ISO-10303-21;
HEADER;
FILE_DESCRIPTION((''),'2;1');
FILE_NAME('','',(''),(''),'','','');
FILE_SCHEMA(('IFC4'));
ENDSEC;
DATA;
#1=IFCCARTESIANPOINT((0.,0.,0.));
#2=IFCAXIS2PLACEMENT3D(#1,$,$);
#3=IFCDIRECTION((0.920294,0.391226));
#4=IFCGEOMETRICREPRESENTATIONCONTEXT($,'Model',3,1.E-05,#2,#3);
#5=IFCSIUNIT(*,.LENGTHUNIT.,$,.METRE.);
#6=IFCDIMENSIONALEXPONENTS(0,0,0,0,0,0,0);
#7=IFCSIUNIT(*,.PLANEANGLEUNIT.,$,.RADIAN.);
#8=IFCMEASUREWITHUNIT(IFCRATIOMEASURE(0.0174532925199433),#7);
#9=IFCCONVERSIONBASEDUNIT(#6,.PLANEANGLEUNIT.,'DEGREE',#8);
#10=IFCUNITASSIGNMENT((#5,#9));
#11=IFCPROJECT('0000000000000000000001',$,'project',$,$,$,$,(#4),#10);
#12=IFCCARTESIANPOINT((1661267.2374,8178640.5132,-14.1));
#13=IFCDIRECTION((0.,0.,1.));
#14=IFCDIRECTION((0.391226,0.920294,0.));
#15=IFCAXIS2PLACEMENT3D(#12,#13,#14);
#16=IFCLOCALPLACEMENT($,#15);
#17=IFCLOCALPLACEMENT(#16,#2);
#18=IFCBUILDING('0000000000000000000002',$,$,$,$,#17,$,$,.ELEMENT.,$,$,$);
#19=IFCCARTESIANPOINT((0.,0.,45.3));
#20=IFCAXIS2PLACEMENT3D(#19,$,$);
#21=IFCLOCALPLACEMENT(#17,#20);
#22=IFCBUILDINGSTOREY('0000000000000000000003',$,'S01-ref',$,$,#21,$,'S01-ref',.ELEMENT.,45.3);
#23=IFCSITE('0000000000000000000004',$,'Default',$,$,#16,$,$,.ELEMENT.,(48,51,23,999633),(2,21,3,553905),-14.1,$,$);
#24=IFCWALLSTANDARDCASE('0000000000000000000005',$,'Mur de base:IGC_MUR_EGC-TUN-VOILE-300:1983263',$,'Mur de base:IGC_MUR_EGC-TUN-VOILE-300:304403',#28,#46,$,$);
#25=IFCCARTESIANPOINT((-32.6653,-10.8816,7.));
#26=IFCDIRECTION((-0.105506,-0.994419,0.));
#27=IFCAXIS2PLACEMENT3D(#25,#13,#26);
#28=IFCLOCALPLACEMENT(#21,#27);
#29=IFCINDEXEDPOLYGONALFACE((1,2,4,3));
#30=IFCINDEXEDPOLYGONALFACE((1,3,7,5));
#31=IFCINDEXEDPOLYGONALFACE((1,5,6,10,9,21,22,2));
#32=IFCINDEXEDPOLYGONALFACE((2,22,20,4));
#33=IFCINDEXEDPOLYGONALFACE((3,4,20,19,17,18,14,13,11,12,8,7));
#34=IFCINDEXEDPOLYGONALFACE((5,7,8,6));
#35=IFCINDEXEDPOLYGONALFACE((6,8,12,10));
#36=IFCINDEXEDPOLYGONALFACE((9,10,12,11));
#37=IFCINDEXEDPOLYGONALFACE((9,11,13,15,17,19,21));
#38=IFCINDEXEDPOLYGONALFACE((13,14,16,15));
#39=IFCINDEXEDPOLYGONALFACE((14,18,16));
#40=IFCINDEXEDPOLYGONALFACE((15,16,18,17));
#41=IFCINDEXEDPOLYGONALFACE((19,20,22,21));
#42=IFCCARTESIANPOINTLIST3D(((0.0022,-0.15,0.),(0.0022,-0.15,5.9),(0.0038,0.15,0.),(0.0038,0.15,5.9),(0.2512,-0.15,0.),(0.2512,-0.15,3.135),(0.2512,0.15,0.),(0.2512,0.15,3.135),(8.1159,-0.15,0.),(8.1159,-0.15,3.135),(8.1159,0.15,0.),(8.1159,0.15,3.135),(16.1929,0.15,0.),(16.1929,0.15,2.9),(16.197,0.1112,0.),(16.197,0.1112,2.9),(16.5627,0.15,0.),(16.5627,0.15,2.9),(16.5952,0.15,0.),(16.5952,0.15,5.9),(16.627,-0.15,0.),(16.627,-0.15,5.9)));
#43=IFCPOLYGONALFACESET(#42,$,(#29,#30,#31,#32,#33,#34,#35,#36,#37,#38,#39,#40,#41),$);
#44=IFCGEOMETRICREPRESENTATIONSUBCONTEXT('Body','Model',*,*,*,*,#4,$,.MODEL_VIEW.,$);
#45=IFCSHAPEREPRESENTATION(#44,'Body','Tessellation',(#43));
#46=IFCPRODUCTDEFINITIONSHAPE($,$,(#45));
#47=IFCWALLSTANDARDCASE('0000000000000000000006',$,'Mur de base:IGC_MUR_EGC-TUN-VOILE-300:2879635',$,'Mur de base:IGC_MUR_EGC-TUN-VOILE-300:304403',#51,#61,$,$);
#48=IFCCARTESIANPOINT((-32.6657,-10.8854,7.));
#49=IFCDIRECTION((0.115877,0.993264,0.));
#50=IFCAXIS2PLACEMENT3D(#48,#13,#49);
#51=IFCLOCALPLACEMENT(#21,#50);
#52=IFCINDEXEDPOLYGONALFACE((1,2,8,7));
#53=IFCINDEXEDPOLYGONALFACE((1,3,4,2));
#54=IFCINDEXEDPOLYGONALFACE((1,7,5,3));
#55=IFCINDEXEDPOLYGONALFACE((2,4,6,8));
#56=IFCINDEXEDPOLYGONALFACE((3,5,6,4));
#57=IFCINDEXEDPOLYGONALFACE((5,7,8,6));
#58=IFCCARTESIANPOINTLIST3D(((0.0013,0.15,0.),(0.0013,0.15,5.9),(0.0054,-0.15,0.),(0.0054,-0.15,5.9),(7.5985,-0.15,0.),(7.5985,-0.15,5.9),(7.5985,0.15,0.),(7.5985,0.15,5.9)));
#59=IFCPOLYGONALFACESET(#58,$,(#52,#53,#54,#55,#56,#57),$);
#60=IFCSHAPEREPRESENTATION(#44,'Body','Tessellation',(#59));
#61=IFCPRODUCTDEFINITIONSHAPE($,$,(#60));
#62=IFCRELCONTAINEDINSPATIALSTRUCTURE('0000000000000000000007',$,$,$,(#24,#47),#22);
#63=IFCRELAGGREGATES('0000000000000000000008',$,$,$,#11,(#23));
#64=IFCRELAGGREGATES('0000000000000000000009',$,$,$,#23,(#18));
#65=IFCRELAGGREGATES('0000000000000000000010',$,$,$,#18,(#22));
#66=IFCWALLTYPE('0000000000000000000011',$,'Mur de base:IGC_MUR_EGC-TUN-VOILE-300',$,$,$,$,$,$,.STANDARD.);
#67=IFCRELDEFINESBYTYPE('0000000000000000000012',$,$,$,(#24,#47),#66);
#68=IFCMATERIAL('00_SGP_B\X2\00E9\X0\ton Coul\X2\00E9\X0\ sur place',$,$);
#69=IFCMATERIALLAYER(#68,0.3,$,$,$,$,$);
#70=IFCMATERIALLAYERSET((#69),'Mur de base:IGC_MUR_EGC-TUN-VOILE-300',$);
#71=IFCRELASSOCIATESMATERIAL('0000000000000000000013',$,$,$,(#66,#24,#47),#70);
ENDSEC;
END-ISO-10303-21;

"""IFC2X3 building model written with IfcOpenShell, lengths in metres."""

from ifc_helpers import new_model, entity, si_unit, converted_unit, direction, frame, frame_2d, origin, origin_2d_with_axis, place, context, subcontext, project, spatial, polyline, rectangle, outline, extrude, material, layer, layer_set, layer_usage, type_object, element, save


model = new_model("IFC2X3")

# Units and contexts
model_context = context("Model", 3, precision=1e-05, world=origin(), true_north=direction((0.920294, 0.391226)))
body_context = subcontext(model_context, "Body", "Model", "MODEL_VIEW")
ifc_project = project(units=[si_unit("LENGTHUNIT", "METRE"), converted_unit("PLANEANGLEUNIT", "DEGREE", entity("IfcRatioMeasure", 0.0174532925199433), si_unit("PLANEANGLEUNIT", "RADIAN"), dimensions=[0, 0, 0, 0, 0, 0, 0])], contexts=[model_context])

# Site, building, storey
site_placement = place(None, frame((1661267.2374, 8178640.5132, -14.1), z_axis=(0.0, 0.0, 1.0), x_axis=(0.391226, 0.920294, 0.0)))
site = spatial("IfcSite", under=ifc_project, at=site_placement, Name="Default", CompositionType="ELEMENT", RefLatitude=(48, 51, 23, 999633), RefLongitude=(2, 21, 3, 553905), RefElevation=-14.1)
building_placement = place(site_placement, origin())
building = spatial("IfcBuilding", under=site, at=building_placement, CompositionType="ELEMENT")
storey_placement = place(building_placement, frame((0.0, 0.0, 45.3)))
storey = spatial("IfcBuildingStorey", under=building, at=storey_placement, Name="S01-ref", LongName="S01-ref", CompositionType="ELEMENT", Elevation=45.3)

# Shared definitions
ifc_material_1 = material(Name="00_SGP_Béton Coulé sur place")

# Wall, openings
ifc_layer_1 = layer(ifc_material_1, 0.3)
ifc_layer_set_1 = layer_set([ifc_layer_1], Name="Mur de base:IGC_MUR_EGC-TUN-VOILE-300")
ifc_layer_usage_1 = layer_usage(ifc_layer_set_1, "AXIS2", "NEGATIVE", 0.15)
wall_type_1 = type_object("IfcWallType", Name="Mur de base:IGC_MUR_EGC-TUN-VOILE-300", PredefinedType="STANDARD", material=ifc_layer_set_1)
wall_1_placement = place(storey_placement, frame((-32.6653, -10.8816, 7.0), z_axis=(0.0, 0.0, 1.0), x_axis=(-0.105506, -0.994419, 0.0)))
wall_1 = element("IfcWallStandardCase", 1, at=wall_1_placement, inside=storey, type_object=wall_type_1, material=ifc_layer_usage_1, Name="Mur de base:IGC_MUR_EGC-TUN-VOILE-300:1983263", ObjectType="Mur de base:IGC_MUR_EGC-TUN-VOILE-300:304403", context=body_context, shape_type="SweptSolid", body=[
    extrude(outline(polyline([(0.0022, -0.15), (16.627, -0.15), (16.5952, 0.15), (16.1929, 0.15), (0.0038, 0.15), (0.0022, -0.15)])), origin(), (0.0, 0.0, 1.0), 5.9),
])
opening_1_placement = place(wall_1_placement, origin())
element("IfcOpeningElement", 2, at=opening_1_placement, cuts=wall_1, ObjectType="Opening", context=body_context, shape_type="SweptSolid", body=[
    extrude(rectangle(XDim=3.135, YDim=7.8648, at=origin_2d_with_axis()), frame((4.1835, -1.374, 1.5675), z_axis=(0.0, 1.0, 0.0), x_axis=(0.0, 0.0, -1.0)), (0.0, 0.0, 1.0), 3.048),
])
opening_2_placement = place(wall_1_placement, origin())
element("IfcOpeningElement", 3, at=opening_2_placement, cuts=wall_1, ObjectType="Opening", context=body_context, shape_type="SweptSolid", body=[
    extrude(rectangle(XDim=2.9, YDim=0.4, at=frame_2d((0.0, 0.0), x_axis=(0.0, 1.0))), frame((16.3959, 0.1323, 1.45), z_axis=(-0.105506, 0.994419, 0.0), x_axis=(-0.994419, -0.105506, 0.0)), (0.0, 0.0, 1.0), 1.51),
])

# Wall
ifc_layer_usage_2 = layer_usage(ifc_layer_set_1, "AXIS2", "NEGATIVE", 0.15)
wall_2_placement = place(storey_placement, frame((-32.6657, -10.8854, 7.0), z_axis=(0.0, 0.0, 1.0), x_axis=(0.115877, 0.993264, 0.0)))
element("IfcWallStandardCase", 4, at=wall_2_placement, inside=storey, type_object=wall_type_1, material=ifc_layer_usage_2, Name="Mur de base:IGC_MUR_EGC-TUN-VOILE-300:2879635", ObjectType="Mur de base:IGC_MUR_EGC-TUN-VOILE-300:304403", context=body_context, shape_type="SweptSolid", body=[
    extrude(outline(polyline([(7.5985, -0.15), (7.5985, 0.15), (0.0013, 0.15), (0.0054, -0.15), (7.5985, -0.15)])), origin(), (0.0, 0.0, 1.0), 5.9),
])

save(model, "model.ifc")
